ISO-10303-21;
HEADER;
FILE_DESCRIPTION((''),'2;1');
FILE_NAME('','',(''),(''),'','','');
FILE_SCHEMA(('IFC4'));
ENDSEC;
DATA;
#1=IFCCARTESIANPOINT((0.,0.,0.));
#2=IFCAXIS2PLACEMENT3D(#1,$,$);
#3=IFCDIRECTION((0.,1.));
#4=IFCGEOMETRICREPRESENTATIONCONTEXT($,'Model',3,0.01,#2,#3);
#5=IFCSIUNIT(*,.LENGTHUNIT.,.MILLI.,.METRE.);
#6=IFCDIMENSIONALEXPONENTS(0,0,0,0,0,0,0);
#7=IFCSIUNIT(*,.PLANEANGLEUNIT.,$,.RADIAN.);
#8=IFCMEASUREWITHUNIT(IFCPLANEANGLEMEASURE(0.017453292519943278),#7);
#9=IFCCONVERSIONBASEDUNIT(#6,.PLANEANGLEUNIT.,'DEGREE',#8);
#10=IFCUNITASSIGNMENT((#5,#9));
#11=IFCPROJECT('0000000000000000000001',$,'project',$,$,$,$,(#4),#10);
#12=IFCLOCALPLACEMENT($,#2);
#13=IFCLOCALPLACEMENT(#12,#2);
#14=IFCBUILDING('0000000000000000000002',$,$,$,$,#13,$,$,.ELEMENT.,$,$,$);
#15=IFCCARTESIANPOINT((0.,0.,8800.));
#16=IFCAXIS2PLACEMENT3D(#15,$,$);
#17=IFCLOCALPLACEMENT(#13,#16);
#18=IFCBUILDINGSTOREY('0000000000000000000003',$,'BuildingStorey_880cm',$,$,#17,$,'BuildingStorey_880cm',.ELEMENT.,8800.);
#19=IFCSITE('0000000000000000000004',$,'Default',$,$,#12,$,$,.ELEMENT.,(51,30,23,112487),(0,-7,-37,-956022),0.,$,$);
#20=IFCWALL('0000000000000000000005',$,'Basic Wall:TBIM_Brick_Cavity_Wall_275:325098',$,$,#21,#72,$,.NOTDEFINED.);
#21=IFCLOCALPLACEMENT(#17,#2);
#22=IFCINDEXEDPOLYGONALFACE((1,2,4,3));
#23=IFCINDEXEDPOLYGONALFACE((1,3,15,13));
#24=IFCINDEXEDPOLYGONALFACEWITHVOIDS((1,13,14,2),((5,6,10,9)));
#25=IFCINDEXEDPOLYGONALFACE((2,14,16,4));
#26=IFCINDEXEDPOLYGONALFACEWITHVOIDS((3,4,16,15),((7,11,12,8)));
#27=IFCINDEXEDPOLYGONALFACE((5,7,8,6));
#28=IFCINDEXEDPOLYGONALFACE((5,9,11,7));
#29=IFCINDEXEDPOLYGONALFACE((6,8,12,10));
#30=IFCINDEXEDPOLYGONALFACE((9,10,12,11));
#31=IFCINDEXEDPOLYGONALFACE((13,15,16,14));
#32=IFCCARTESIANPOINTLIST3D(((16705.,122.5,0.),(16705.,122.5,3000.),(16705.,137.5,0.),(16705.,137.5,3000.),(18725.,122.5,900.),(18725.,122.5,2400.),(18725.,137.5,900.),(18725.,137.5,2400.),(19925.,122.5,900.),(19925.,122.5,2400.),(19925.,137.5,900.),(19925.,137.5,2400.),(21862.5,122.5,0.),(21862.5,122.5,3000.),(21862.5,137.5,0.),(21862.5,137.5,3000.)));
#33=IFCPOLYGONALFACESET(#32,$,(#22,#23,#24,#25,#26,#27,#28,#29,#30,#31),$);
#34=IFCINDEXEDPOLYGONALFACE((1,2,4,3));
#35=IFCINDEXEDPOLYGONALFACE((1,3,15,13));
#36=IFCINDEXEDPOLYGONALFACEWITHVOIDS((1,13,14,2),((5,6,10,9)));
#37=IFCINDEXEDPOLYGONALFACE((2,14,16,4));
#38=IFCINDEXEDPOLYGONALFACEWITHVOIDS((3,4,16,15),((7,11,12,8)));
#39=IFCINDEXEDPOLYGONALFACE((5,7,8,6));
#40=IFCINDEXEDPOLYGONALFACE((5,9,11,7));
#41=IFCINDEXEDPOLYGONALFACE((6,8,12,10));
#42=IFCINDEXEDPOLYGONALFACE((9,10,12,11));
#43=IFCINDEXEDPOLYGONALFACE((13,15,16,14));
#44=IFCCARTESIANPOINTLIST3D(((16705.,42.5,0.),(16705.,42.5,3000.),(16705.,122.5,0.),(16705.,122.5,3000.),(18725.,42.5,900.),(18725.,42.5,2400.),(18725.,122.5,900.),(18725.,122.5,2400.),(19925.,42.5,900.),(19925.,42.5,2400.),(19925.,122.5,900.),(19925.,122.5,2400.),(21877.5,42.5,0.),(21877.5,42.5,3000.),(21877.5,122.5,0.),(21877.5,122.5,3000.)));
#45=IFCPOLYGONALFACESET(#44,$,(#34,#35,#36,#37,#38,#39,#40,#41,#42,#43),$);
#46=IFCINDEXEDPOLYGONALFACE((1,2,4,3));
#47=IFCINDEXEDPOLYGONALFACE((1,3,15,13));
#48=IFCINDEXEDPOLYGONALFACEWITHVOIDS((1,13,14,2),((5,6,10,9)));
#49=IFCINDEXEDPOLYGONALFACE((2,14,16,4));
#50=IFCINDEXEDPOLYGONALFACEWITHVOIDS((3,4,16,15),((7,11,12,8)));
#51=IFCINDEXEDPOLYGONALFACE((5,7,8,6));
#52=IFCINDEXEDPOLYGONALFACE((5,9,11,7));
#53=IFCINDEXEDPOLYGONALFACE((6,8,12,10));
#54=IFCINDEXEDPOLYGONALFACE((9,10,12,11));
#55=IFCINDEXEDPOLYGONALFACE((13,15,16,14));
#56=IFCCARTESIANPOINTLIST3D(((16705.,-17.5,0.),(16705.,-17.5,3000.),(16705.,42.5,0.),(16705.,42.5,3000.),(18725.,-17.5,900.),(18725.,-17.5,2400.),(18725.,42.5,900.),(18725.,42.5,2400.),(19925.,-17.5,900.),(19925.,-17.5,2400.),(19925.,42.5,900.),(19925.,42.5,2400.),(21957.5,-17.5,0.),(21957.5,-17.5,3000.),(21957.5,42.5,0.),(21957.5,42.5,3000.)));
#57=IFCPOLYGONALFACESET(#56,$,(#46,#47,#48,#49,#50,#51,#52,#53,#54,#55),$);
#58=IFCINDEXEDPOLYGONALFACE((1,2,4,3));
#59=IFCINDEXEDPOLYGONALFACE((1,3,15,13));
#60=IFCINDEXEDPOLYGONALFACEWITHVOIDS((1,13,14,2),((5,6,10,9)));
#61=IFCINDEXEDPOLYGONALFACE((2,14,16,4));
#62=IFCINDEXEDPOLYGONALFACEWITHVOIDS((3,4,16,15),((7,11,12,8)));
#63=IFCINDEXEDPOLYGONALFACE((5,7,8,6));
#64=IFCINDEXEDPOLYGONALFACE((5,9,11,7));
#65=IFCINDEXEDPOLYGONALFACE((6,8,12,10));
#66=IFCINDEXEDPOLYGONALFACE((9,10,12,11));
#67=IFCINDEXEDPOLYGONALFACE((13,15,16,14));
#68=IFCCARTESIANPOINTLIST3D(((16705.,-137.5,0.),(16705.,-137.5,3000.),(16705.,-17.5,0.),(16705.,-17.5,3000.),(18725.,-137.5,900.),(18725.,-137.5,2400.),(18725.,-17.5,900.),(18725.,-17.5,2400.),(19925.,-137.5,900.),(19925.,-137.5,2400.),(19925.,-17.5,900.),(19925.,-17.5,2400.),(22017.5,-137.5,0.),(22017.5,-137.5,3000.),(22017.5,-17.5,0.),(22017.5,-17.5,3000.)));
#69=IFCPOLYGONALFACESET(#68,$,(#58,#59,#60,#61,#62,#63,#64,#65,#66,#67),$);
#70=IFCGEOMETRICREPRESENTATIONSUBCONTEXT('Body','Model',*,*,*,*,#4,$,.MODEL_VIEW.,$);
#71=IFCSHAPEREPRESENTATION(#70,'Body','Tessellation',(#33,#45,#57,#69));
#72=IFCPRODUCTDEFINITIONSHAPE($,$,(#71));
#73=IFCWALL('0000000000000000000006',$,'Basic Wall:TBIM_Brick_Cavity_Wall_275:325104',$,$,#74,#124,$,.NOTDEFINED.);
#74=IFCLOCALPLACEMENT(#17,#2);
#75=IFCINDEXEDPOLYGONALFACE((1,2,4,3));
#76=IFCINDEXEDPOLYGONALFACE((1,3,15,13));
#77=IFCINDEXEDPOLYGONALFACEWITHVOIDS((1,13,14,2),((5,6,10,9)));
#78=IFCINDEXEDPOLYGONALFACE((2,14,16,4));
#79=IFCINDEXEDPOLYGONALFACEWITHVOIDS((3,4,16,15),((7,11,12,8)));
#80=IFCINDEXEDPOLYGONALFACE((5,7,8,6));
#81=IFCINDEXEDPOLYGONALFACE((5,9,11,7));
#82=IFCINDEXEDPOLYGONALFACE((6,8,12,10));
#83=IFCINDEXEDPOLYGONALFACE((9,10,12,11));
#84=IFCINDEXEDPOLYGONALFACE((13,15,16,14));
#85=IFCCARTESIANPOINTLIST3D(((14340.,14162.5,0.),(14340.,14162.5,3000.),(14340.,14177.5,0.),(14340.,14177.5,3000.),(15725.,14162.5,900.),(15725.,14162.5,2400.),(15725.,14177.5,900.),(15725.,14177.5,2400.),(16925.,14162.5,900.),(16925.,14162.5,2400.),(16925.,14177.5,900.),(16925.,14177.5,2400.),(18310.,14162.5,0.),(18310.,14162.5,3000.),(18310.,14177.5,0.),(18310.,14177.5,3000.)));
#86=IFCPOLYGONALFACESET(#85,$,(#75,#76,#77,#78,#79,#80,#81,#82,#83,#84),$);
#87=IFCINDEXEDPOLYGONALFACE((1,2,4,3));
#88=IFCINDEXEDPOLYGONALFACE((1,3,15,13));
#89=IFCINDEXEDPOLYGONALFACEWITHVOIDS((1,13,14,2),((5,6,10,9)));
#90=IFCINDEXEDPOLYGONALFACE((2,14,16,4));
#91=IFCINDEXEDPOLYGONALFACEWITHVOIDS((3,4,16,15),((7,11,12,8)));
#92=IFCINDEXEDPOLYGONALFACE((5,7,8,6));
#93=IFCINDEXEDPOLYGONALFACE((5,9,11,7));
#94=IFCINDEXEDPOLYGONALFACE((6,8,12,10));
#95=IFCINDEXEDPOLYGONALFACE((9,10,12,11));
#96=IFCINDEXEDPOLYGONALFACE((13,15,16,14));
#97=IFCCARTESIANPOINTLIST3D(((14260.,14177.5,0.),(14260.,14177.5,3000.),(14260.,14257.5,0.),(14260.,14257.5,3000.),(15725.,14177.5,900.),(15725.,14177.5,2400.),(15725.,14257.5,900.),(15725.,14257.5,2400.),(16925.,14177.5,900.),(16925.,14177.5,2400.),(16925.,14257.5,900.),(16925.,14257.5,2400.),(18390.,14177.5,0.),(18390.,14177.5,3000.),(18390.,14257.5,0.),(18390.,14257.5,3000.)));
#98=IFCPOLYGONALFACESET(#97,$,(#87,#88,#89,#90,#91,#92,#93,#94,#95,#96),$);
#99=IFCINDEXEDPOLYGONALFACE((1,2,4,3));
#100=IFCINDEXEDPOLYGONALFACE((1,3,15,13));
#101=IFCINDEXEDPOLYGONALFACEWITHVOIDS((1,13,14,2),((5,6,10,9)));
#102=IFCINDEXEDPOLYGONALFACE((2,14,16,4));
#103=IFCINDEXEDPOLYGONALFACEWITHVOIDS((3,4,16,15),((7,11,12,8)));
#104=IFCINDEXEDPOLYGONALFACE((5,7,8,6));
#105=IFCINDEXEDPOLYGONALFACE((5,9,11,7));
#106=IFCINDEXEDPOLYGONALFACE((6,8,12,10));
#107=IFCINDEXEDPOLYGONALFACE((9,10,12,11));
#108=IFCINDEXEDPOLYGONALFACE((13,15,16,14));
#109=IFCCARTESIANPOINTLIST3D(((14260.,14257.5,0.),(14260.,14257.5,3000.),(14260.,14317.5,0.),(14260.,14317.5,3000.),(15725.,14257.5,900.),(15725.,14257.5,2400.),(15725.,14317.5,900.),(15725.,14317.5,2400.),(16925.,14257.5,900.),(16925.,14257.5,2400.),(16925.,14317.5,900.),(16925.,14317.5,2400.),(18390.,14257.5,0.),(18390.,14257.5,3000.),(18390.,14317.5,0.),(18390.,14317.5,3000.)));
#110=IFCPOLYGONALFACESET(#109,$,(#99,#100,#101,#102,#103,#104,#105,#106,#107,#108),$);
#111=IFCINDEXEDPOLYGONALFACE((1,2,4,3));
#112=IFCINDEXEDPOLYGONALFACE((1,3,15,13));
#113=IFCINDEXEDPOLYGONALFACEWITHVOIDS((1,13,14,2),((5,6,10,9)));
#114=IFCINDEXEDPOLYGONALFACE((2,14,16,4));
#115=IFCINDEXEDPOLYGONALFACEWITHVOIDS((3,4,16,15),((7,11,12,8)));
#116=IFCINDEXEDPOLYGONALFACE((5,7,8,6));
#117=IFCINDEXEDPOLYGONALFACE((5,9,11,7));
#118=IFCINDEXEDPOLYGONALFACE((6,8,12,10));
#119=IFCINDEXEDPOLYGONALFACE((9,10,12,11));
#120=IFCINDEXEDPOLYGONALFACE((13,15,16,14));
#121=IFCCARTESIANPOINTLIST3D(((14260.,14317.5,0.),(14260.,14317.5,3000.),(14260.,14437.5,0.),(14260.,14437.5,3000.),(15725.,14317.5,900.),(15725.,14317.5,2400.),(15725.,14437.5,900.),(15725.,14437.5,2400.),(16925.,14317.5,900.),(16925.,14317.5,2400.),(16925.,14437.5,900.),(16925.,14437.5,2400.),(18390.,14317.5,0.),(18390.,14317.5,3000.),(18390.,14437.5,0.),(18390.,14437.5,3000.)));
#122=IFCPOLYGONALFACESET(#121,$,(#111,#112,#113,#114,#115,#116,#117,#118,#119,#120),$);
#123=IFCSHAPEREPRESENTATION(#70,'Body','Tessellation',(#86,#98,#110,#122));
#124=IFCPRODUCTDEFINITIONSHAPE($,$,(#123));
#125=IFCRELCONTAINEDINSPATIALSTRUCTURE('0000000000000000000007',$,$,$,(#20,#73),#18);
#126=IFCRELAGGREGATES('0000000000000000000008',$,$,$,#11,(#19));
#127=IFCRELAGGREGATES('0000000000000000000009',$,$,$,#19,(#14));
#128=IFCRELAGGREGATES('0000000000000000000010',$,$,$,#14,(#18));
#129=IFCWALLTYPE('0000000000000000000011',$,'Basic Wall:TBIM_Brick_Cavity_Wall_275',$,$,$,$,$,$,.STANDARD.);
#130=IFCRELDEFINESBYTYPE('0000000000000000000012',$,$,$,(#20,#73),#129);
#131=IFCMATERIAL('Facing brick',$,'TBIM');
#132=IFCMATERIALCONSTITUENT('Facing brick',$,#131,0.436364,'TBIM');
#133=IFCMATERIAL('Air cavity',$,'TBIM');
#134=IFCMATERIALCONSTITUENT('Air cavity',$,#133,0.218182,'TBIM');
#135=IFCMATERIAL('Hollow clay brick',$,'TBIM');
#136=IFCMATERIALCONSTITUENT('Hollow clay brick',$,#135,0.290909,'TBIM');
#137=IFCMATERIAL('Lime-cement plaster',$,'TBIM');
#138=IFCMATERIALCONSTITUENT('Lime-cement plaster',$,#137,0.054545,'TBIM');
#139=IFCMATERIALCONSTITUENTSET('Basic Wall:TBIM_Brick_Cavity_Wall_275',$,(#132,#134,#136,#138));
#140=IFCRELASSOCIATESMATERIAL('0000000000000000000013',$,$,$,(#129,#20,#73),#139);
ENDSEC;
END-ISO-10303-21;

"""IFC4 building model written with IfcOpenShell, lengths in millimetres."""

from ifc_helpers import new_model, entity, si_unit, converted_unit, direction, frame, origin, place, context, subcontext, project, spatial, indexed_curve, outline, extrude, material, constituent, constituent_set, type_object, element, save


model = new_model("IFC4")

# Units and contexts
model_context = context("Model", 3, precision=0.01, world=origin(), true_north=direction((0.0, 1.0)))
body_context = subcontext(model_context, "Body", "Model", "MODEL_VIEW")
ifc_project = project(units=[si_unit("LENGTHUNIT", "METRE", prefix="MILLI"), converted_unit("PLANEANGLEUNIT", "DEGREE", entity("IfcPlaneAngleMeasure", 0.017453292519943278), si_unit("PLANEANGLEUNIT", "RADIAN"), dimensions=[0, 0, 0, 0, 0, 0, 0])], contexts=[model_context])

# Site, building, storey
site_placement = place(None, origin())
site = spatial("IfcSite", under=ifc_project, at=site_placement, Name="Default", CompositionType="ELEMENT", RefLatitude=(51, 30, 23, 112487), RefLongitude=(0, -7, -37, -956022), RefElevation=0.0)
building_placement = place(site_placement, origin())
building = spatial("IfcBuilding", under=site, at=building_placement, CompositionType="ELEMENT")
storey_placement = place(building_placement, frame((0.0, 0.0, 8800.0)))
storey = spatial("IfcBuildingStorey", under=building, at=storey_placement, Name="BuildingStorey_880cm", LongName="BuildingStorey_880cm", CompositionType="ELEMENT", Elevation=8800.0)

# Walls, openings
ifc_material_1 = material(Name="Facing brick", Category="TBIM")
ifc_constituent_1 = constituent(ifc_material_1, Name="Facing brick", Category="TBIM", fraction=0.436364)
ifc_material_2 = material(Name="Air cavity", Category="TBIM")
ifc_constituent_2 = constituent(ifc_material_2, Name="Air cavity", Category="TBIM", fraction=0.218182)
ifc_material_3 = material(Name="Hollow clay brick", Category="TBIM")
ifc_constituent_3 = constituent(ifc_material_3, Name="Hollow clay brick", Category="TBIM", fraction=0.290909)
ifc_material_4 = material(Name="Lime-cement plaster", Category="TBIM")
ifc_constituent_4 = constituent(ifc_material_4, Name="Lime-cement plaster", Category="TBIM", fraction=0.054545)
ifc_constituent_set_1 = constituent_set(constituents=[ifc_constituent_1, ifc_constituent_2, ifc_constituent_3, ifc_constituent_4], Name="Basic Wall:TBIM_Brick_Cavity_Wall_275")
wall_type_1 = type_object("IfcWallType", Name="Basic Wall:TBIM_Brick_Cavity_Wall_275", PredefinedType="STANDARD", material=ifc_constituent_set_1)
wall_1_placement = place(storey_placement, frame((16705.0, 0.0, 0.0)))
wall_1 = element("IfcWall", 1, at=wall_1_placement, inside=storey, type_object=wall_type_1, material=ifc_constituent_set_1, Name="Basic Wall:TBIM_Brick_Cavity_Wall_275:325098", PredefinedType="NOTDEFINED", context=body_context, shape_type="SweptSolid", body=[
    extrude(outline(indexed_curve([(-1500.0, -2578.8), (1500.0, -2578.8), (1500.0, 2578.8), (-1500.0, 2578.8), (-1500.0, -2578.8)], self_intersect=False), holes=[indexed_curve([(-600.0, -558.8), (-600.0, 641.2), (900.0, 641.2), (900.0, -558.8), (-600.0, -558.8)], self_intersect=False)]), frame((2578.8, 122.5, 1500.0), z_axis=(0.0, 1.0, 0.0), x_axis=(0.0, 0.0, 1.0)), (0.0, 0.0, 1.0), 15.0),
    extrude(outline(indexed_curve([(-1500.0, -2586.3), (1500.0, -2586.3), (1500.0, 2586.3), (-1500.0, 2586.3), (-1500.0, -2586.3)], self_intersect=False), holes=[indexed_curve([(-600.0, -566.3), (-600.0, 633.7), (900.0, 633.7), (900.0, -566.3), (-600.0, -566.3)], self_intersect=False)]), frame((2586.3, 42.5, 1500.0), z_axis=(0.0, 1.0, 0.0), x_axis=(0.0, 0.0, 1.0)), (0.0, 0.0, 1.0), 80.0),
    extrude(outline(indexed_curve([(-1500.0, -2626.3), (1500.0, -2626.3), (1500.0, 2626.3), (-1500.0, 2626.3), (-1500.0, -2626.3)], self_intersect=False), holes=[indexed_curve([(-600.0, -606.3), (-600.0, 593.7), (900.0, 593.7), (900.0, -606.3), (-600.0, -606.3)], self_intersect=False)]), frame((2626.3, -17.5, 1500.0), z_axis=(0.0, 1.0, 0.0), x_axis=(0.0, 0.0, 1.0)), (0.0, 0.0, 1.0), 60.0),
    extrude(outline(indexed_curve([(-1500.0, -2656.3), (1500.0, -2656.3), (1500.0, 2656.3), (-1500.0, 2656.3), (-1500.0, -2656.3)], self_intersect=False), holes=[indexed_curve([(900.0, -636.3), (-600.0, -636.3), (-600.0, 563.7), (900.0, 563.7), (900.0, -636.3)], self_intersect=False)]), frame((2656.3, -137.5, 1500.0), z_axis=(0.0, 1.0, 0.0), x_axis=(0.0, 0.0, 1.0)), (0.0, 0.0, 1.0), 120.0),
])
opening_1_placement = place(wall_1_placement, frame((2020.0, -137.5, 900.0)))
element("IfcOpeningElement", 2, at=opening_1_placement, cuts=wall_1, PredefinedType="OPENING", context=body_context, shape_type="SweptSolid", body=[
    extrude(outline(indexed_curve([(1500.0, 0.0), (1500.0, 1200.0), (0.0, 1200.0), (0.0, 0.0), (1500.0, 0.0)], self_intersect=False)), frame((0.0, 0.0, 0.0), z_axis=(0.0, 1.0, 0.0), x_axis=(0.0, 0.0, 1.0)), (0.0, 0.0, 1.0), 275.0),
])
wall_2_placement = place(storey_placement, frame((14245.0, 14300.0, 0.0)))
wall_2 = element("IfcWall", 3, at=wall_2_placement, inside=storey, type_object=wall_type_1, material=ifc_constituent_set_1, Name="Basic Wall:TBIM_Brick_Cavity_Wall_275:325104", PredefinedType="NOTDEFINED", context=body_context, shape_type="SweptSolid", body=[
    extrude(outline(indexed_curve([(-1500.0, -1985.0), (1500.0, -1985.0), (1500.0, -1970.0), (1500.0, 1970.0), (1500.0, 1985.0), (-1500.0, 1985.0), (-1500.0, 1970.0), (-1500.0, -1970.0), (-1500.0, -1985.0)], self_intersect=False), holes=[indexed_curve([(900.0, -600.0), (-600.0, -600.0), (-600.0, 600.0), (900.0, 600.0), (900.0, -600.0)], self_intersect=False)]), frame((2080.0, -137.5, 1500.0), z_axis=(0.0, 1.0, 0.0), x_axis=(0.0, 0.0, 1.0)), (0.0, 0.0, 1.0), 15.0),
    extrude(outline(indexed_curve([(-1500.0, -2065.0), (1500.0, -2065.0), (1500.0, 2065.0), (-1500.0, 2065.0), (-1500.0, -2065.0)], self_intersect=False), holes=[indexed_curve([(-600.0, -600.0), (-600.0, 600.0), (900.0, 600.0), (900.0, -600.0), (-600.0, -600.0)], self_intersect=False)]), frame((2080.0, -122.5, 1500.0), z_axis=(0.0, 1.0, 0.0), x_axis=(0.0, 0.0, 1.0)), (0.0, 0.0, 1.0), 80.0),
    extrude(outline(indexed_curve([(-1500.0, -2065.0), (1500.0, -2065.0), (1500.0, 2065.0), (-1500.0, 2065.0), (-1500.0, -2065.0)], self_intersect=False), holes=[indexed_curve([(-600.0, -600.0), (-600.0, 600.0), (900.0, 600.0), (900.0, -600.0), (-600.0, -600.0)], self_intersect=False)]), frame((2080.0, -42.5, 1500.0), z_axis=(0.0, 1.0, 0.0), x_axis=(0.0, 0.0, 1.0)), (0.0, 0.0, 1.0), 60.0),
    extrude(outline(indexed_curve([(-1500.0, -2065.0), (1500.0, -2065.0), (1500.0, 2065.0), (-1500.0, 2065.0), (-1500.0, -2065.0)], self_intersect=False), holes=[indexed_curve([(-600.0, -600.0), (-600.0, 600.0), (900.0, 600.0), (900.0, -600.0), (-600.0, -600.0)], self_intersect=False)]), frame((2080.0, 17.5, 1500.0), z_axis=(0.0, 1.0, 0.0), x_axis=(0.0, 0.0, 1.0)), (0.0, 0.0, 1.0), 120.0),
])
opening_2_placement = place(wall_2_placement, frame((1480.0, -137.5, 900.0)))
element("IfcOpeningElement", 4, at=opening_2_placement, cuts=wall_2, PredefinedType="OPENING", context=body_context, shape_type="SweptSolid", body=[
    extrude(outline(indexed_curve([(1500.0, 0.0), (1500.0, 1200.0), (0.0, 1200.0), (0.0, 0.0), (1500.0, 0.0)], self_intersect=False)), frame((0.0, 0.0, 0.0), z_axis=(0.0, 1.0, 0.0), x_axis=(0.0, 0.0, 1.0)), (0.0, 0.0, 1.0), 275.0),
])

save(model, "model.ifc")
